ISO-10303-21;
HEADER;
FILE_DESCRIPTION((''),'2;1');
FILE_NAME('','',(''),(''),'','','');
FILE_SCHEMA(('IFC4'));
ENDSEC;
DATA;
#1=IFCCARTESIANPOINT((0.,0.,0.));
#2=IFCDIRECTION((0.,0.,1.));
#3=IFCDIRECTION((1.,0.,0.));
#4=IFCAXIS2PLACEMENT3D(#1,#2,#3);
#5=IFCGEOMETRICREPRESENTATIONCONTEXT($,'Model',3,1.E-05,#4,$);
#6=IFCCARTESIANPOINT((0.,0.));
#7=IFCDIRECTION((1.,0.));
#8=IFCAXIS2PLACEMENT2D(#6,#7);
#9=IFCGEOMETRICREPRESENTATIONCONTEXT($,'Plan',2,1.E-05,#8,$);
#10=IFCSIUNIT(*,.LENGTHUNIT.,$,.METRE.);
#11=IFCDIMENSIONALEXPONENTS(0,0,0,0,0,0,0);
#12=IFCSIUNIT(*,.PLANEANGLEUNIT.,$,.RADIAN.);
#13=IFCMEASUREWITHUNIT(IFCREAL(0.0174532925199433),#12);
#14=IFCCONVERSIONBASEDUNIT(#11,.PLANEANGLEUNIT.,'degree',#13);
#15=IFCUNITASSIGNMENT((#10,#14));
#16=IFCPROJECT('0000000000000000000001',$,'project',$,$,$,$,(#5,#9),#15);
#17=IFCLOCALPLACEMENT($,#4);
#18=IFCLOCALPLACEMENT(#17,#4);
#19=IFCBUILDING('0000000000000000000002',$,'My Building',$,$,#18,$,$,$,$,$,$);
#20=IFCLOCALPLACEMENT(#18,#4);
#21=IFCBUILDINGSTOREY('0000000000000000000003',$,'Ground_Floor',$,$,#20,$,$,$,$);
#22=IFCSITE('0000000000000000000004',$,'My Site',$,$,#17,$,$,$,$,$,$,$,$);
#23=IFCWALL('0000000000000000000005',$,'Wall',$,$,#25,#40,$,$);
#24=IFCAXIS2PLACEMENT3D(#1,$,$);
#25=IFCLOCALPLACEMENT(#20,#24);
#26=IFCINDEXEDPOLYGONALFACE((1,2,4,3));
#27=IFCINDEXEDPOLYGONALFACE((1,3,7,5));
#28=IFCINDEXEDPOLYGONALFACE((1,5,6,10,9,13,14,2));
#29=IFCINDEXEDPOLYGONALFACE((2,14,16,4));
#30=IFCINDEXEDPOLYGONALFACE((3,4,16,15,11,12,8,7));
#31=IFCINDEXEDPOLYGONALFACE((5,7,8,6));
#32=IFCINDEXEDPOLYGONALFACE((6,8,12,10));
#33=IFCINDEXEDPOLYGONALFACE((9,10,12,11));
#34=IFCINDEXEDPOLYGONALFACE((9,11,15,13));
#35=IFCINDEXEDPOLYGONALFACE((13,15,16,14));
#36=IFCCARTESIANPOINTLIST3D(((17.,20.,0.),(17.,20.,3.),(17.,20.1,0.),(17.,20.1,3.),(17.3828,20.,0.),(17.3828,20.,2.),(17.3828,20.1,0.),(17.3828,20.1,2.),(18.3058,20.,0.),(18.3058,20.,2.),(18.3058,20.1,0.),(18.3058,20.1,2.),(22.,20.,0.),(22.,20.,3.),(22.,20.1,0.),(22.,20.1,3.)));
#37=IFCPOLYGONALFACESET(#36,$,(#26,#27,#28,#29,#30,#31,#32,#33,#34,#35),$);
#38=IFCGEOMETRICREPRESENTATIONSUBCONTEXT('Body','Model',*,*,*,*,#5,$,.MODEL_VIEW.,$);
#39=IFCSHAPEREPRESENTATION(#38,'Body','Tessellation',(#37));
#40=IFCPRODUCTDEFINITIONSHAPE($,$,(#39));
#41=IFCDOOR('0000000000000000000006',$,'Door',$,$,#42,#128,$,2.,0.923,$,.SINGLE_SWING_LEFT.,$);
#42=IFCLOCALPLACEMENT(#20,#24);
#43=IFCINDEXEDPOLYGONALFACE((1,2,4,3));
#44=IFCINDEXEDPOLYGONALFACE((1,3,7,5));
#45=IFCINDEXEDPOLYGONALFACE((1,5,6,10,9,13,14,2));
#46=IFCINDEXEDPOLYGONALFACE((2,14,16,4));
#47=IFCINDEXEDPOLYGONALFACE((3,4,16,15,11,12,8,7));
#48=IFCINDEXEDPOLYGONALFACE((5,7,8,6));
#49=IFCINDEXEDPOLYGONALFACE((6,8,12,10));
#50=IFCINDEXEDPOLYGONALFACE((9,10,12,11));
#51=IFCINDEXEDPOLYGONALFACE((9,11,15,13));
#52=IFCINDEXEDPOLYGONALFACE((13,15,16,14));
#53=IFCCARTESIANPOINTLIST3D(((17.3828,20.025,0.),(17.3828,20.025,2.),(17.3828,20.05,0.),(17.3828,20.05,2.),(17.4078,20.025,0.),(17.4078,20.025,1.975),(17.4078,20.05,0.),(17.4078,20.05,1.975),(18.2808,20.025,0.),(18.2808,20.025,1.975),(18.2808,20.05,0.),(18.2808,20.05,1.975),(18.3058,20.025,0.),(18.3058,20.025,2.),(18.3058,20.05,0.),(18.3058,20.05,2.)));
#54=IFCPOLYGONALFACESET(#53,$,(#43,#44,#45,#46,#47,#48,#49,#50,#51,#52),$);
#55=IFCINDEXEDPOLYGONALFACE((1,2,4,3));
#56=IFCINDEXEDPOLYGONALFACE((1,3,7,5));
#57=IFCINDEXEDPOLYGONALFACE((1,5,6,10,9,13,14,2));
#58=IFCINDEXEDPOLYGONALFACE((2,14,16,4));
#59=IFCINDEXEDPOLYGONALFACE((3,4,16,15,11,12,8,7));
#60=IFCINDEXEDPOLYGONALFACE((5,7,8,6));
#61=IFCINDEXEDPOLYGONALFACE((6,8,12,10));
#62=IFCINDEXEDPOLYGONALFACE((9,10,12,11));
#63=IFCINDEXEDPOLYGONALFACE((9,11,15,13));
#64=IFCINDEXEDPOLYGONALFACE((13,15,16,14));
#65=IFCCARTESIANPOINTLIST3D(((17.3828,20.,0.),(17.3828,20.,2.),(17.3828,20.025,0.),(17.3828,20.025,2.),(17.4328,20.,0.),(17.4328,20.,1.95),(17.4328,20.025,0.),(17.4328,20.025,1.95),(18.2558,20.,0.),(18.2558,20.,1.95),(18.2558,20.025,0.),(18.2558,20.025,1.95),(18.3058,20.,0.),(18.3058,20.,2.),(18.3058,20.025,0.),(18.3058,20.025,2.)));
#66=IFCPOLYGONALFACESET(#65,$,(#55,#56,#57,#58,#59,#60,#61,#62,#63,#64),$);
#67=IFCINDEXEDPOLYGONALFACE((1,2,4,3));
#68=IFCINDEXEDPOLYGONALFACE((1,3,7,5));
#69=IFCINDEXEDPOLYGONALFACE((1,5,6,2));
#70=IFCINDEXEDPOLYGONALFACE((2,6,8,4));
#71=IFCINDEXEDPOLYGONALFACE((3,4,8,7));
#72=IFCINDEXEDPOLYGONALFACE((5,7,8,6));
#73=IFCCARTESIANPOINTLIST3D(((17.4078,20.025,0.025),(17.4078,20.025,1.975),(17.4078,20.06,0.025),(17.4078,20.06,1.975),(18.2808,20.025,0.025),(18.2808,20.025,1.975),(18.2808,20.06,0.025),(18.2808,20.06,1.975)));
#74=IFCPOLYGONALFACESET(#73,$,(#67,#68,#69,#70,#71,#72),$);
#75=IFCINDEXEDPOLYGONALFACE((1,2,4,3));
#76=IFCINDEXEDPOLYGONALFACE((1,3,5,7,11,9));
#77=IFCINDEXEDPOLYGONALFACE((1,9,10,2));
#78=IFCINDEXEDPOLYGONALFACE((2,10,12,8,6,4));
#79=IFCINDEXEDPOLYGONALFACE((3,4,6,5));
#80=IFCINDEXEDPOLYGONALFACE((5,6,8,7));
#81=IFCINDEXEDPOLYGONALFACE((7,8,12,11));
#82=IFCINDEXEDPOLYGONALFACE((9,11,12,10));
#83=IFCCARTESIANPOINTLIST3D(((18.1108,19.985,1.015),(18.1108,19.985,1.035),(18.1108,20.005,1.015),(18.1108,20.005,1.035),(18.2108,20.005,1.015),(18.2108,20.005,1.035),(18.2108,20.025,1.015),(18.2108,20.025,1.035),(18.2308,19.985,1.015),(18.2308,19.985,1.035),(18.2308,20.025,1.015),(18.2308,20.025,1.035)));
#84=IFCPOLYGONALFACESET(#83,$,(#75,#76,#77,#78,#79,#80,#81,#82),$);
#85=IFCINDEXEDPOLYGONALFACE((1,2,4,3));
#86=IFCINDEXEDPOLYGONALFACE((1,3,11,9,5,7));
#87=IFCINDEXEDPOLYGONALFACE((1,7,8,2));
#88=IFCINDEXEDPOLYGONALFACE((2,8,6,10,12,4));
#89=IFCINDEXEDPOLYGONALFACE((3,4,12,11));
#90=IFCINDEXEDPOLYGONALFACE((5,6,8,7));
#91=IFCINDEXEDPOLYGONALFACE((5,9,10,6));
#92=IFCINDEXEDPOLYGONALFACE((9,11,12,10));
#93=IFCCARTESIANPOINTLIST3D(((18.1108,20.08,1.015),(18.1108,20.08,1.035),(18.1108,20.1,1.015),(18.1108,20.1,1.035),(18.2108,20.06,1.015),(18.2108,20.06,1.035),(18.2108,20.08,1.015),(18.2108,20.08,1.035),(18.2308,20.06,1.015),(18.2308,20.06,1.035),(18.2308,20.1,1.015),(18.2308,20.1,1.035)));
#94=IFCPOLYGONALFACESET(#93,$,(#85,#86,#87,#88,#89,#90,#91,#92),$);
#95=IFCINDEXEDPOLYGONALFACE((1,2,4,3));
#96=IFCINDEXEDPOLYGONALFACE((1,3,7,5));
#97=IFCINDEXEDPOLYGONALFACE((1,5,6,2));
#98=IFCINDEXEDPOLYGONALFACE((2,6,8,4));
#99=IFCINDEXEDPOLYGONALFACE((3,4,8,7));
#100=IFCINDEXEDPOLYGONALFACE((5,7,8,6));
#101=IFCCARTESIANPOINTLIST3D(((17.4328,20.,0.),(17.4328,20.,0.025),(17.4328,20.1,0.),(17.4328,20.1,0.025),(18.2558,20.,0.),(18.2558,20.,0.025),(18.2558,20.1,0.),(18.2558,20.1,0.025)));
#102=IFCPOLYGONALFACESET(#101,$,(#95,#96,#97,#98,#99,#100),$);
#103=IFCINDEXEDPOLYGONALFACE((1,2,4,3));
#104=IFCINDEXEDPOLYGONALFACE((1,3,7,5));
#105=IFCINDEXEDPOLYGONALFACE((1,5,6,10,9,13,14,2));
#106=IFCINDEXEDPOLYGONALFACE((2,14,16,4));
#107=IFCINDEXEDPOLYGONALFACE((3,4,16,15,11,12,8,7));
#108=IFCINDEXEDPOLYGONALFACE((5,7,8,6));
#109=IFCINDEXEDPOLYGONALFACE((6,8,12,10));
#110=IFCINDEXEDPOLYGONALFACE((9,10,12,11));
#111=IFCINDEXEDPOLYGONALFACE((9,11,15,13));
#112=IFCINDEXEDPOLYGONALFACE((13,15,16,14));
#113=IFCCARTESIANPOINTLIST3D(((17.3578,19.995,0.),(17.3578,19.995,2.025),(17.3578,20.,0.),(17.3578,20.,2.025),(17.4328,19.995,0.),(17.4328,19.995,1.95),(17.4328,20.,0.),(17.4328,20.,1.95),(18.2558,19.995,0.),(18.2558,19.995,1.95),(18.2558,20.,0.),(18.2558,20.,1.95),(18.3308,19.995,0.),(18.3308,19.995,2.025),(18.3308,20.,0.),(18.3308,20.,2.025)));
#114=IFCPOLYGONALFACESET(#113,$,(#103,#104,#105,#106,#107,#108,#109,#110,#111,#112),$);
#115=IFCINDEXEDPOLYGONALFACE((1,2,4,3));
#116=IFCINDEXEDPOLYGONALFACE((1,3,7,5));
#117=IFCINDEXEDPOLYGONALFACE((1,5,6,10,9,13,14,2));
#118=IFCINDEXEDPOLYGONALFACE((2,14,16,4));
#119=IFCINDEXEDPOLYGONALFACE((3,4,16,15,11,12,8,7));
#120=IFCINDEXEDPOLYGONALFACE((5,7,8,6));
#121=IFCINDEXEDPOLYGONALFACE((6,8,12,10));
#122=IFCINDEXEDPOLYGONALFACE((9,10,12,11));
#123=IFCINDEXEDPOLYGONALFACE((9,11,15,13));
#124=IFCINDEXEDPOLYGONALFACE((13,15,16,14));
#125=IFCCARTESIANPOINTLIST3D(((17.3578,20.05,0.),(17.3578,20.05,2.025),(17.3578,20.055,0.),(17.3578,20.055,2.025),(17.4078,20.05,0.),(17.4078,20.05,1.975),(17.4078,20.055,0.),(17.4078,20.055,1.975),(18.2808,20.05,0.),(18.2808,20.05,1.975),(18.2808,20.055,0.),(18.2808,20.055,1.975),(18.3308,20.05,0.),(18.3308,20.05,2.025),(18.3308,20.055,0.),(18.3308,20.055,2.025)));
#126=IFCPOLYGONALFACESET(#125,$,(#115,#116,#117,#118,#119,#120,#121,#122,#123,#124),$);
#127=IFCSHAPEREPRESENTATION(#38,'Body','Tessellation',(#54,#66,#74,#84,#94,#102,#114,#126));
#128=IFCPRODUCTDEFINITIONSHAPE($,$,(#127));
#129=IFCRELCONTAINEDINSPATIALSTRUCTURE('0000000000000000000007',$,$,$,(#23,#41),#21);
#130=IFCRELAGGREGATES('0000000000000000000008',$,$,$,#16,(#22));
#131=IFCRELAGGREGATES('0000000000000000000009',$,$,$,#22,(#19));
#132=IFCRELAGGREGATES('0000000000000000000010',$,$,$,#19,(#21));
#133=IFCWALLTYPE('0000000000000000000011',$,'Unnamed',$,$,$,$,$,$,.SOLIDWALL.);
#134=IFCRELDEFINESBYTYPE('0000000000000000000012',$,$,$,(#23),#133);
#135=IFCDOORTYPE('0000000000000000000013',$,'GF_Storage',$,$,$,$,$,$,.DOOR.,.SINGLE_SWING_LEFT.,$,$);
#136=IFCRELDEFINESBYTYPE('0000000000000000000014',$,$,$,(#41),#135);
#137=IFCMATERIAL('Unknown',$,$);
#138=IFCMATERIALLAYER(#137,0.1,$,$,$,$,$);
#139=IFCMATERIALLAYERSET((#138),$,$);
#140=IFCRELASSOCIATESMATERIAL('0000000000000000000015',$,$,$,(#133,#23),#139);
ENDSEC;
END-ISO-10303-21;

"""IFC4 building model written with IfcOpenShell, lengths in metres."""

from ifc_helpers import new_model, entity, si_unit, converted_unit, frame, origin_with_axes, origin_2d_with_axis, place, context, subcontext, project, spatial, line, indexed_curve, outline, extrude, shape, source, transform, mapped, material, layer, layer_set, layer_usage, type_object, type_shapes, element, fill, save


model = new_model("IFC4")

# Units and contexts
model_context = context("Model", 3, precision=1e-05, world=origin_with_axes())
plan_context = context("Plan", 2, precision=1e-05, world=origin_2d_with_axis())
body_context_1 = subcontext(model_context, "Body", "Model", "MODEL_VIEW")
body_context_2 = subcontext(plan_context, "Body", "Plan", "PLAN_VIEW")
ifc_project = project(units=[si_unit("LENGTHUNIT", "METRE"), converted_unit("PLANEANGLEUNIT", "degree", entity("IfcReal", 0.0174532925199433), si_unit("PLANEANGLEUNIT", "RADIAN"), dimensions=[0, 0, 0, 0, 0, 0, 0])], contexts=[model_context, plan_context])

# Site, building, storey
site_placement = place(None, origin_with_axes())
site = spatial("IfcSite", under=ifc_project, at=site_placement, Name="My Site")
building_placement = place(site_placement, origin_with_axes())
building = spatial("IfcBuilding", under=site, at=building_placement, Name="My Building")
storey_placement = place(building_placement, origin_with_axes())
storey = spatial("IfcBuildingStorey", under=building, at=storey_placement, Name="Ground_Floor")

# Shared definitions
ifc_material = material(Name="Unknown")
ifc_layer = layer(ifc_material, 0.1)
ifc_layer_set = layer_set([ifc_layer])
wall_type = type_object("IfcWallType", Name="Unnamed", PredefinedType="SOLIDWALL", material=ifc_layer_set)

# Wall, opening, door
ifc_layer_usage_1 = layer_usage(ifc_layer_set, "AXIS2", "POSITIVE", 0.0)
wall_1_placement = place(storey_placement, frame((17.0, 20.0, 0.0), z_axis=(0.0, 0.0, 1.0), x_axis=(1.0, 0.0, 0.0)))
wall_1 = element("IfcWall", 1, at=wall_1_placement, inside=storey, type_object=wall_type, material=ifc_layer_usage_1, Name="Wall", context=body_context_1, shape_type="SweptSolid", body=[
    extrude(outline(indexed_curve([(0.0, 0.0), (0.0, 0.1), (5.0, 0.1), (5.0, 0.0)], segments=[line(1, 2, 3, 4, 1)])), origin_with_axes(), (0.0, 0.0, 1.0), 3.0),
])
shared_shape_1 = source(origin_with_axes(), body_context_1, "Body", "SweptSolid", [
    extrude(outline(indexed_curve([(0.0, 0.0), (0.923, 0.0), (0.923, 2.0), (0.0, 2.0)], segments=[line(1, 2, 3, 4, 1)])), frame((0.0, -0.6, 0.0), z_axis=(0.0, -1.0, 0.0), x_axis=(1.0, 0.0, 0.0)), (0.0, 0.0, -1.0), 1.2),
])
opening_1_placement = place(wall_1_placement, frame((0.3828, 0.0, 0.0), z_axis=(0.0, 0.0, 1.0), x_axis=(1.0, 0.0, 0.0)))
opening_1 = element("IfcOpeningElement", 2, at=opening_1_placement, cuts=wall_1, PredefinedType="OPENING", context=body_context_1, shape_type="MappedRepresentation", body=[
    mapped(shared_shape_1, transform((0.0, 0.0, 0.0), x_axis=(1.0, 0.0, 0.0), y_axis=(0.0, 1.0, 0.0), z_axis=(0.0, 0.0, 1.0), scale=1.0)),
])
door_type_1 = type_object("IfcDoorType", Name="GF_Storage", OperationType="SINGLE_SWING_LEFT", PredefinedType="DOOR")
shared_shape_2 = source(origin_with_axes(), body_context_1, "Body", "SweptSolid", [
    extrude(outline(indexed_curve([(0.0, 0.0), (0.0, 2.0), (0.923, 2.0), (0.923, 0.0), (0.898, 0.0), (0.898, 1.975), (0.025, 1.975), (0.025, 0.0)], segments=[line(1, 2, 3, 4, 5, 6, 7, 8, 1)])), frame((0.0, 0.025, 0.0), z_axis=(0.0, -1.0, 0.0), x_axis=(1.0, 0.0, 0.0)), (0.0, 0.0, -1.0), 0.025),
    extrude(outline(indexed_curve([(0.0, 0.0), (0.0, 2.0), (0.923, 2.0), (0.923, 0.0), (0.873, 0.0), (0.873, 1.95), (0.05, 1.95), (0.05, 0.0)], segments=[line(1, 2, 3, 4, 5, 6, 7, 8, 1)])), frame((0.0, 0.0, 0.0), z_axis=(0.0, -1.0, 0.0), x_axis=(1.0, 0.0, 0.0)), (0.0, 0.0, -1.0), 0.025),
    extrude(outline(indexed_curve([(0.0, 0.0), (0.873, 0.0), (0.873, 0.035), (0.0, 0.035)], segments=[line(1, 2, 3, 4, 1)])), frame((0.025, 0.025, 0.025), z_axis=(0.0, 0.0, 1.0), x_axis=(1.0, 0.0, 0.0)), (0.0, 0.0, 1.0), 1.95),
    extrude(outline(indexed_curve([(0.0, 0.0), (0.0, -0.04), (-0.12, -0.04), (-0.12, -0.02), (-0.02, -0.02), (-0.02, 0.0)], segments=[line(1, 2, 3, 4, 5, 6, 1)])), frame((0.848, 0.025, 1.015), z_axis=(0.0, 0.0, 1.0), x_axis=(1.0, 0.0, 0.0)), (0.0, 0.0, 1.0), 0.02),
    extrude(outline(indexed_curve([(0.0, 0.0), (0.0, 0.04), (-0.12, 0.04), (-0.12, 0.02), (-0.02, 0.02), (-0.02, 0.0)], segments=[line(1, 2, 3, 4, 5, 6, 1)])), frame((0.848, 0.06, 1.015), z_axis=(0.0, 0.0, 1.0), x_axis=(1.0, 0.0, 0.0)), (0.0, 0.0, 1.0), 0.02),
    extrude(outline(indexed_curve([(0.0, 0.0), (0.823, 0.0), (0.823, 0.1), (0.0, 0.1)], segments=[line(1, 2, 3, 4, 1)])), frame((0.05, 0.0, 0.0), z_axis=(0.0, 0.0, 1.0), x_axis=(1.0, 0.0, 0.0)), (0.0, 0.0, 1.0), 0.025),
    extrude(outline(indexed_curve([(0.0, 0.0), (0.0, 2.025), (0.973, 2.025), (0.973, 0.0), (0.898, 0.0), (0.898, 1.95), (0.075, 1.95), (0.075, 0.0)], segments=[line(1, 2, 3, 4, 5, 6, 7, 8, 1)])), frame((-0.025, -0.005, 0.0), z_axis=(0.0, -1.0, 0.0), x_axis=(1.0, 0.0, 0.0)), (0.0, 0.0, -1.0), 0.005),
    extrude(outline(indexed_curve([(0.0, 0.0), (0.0, 2.025), (0.973, 2.025), (0.973, 0.0), (0.923, 0.0), (0.923, 1.975), (0.05, 1.975), (0.05, 0.0)], segments=[line(1, 2, 3, 4, 5, 6, 7, 8, 1)])), frame((-0.025, 0.05, 0.0), z_axis=(0.0, -1.0, 0.0), x_axis=(1.0, 0.0, 0.0)), (0.0, 0.0, -1.0), 0.005),
])
shared_shape_3 = source(origin_with_axes(), body_context_2, "Body", "Curve2D", [
    entity("IfcIndexedPolyCurve", entity("IfcCartesianPointList2D", [[0.0, 0.0], [0.0, 0.05], [0.025, 0.05], [0.025, 0.025], [0.05, 0.025], [0.05, 0.0]]), [entity("IfcLineIndex", [1, 2, 3, 4, 5, 6, 1])]),
    entity("IfcIndexedPolyCurve", entity("IfcCartesianPointList2D", [[0.923, 0.0], [0.923, 0.05], [0.898, 0.05], [0.898, 0.025], [0.873, 0.025], [0.873, 0.0]]), [entity("IfcLineIndex", [1, 2, 3, 4, 5, 6, 1])]),
    entity("IfcTrimmedCurve", entity("IfcEllipse", entity("IfcAxis2Placement2D", entity("IfcCartesianPoint", [0.06, 0.05]), entity("IfcDirection", [1.0, 0.0])), 0.838, 0.873), [entity("IfcCartesianPoint", [0.898, 0.05])], [entity("IfcCartesianPoint", [0.06, 0.923])], True, "CARTESIAN"),
    entity("IfcIndexedPolyCurve", entity("IfcCartesianPointList2D", [[0.025, 0.05], [0.06, 0.05], [0.06, 0.923], [0.025, 0.923]]), [entity("IfcLineIndex", [1, 2, 3, 4, 1])]),
])
type_shapes(door_type_1, [shared_shape_2, shared_shape_3])
door_1_placement = place(opening_1_placement, frame((0.0, 0.0, 0.0), z_axis=(0.0, 0.0, 1.0), x_axis=(1.0, 0.0, 0.0)))
door_1 = element("IfcDoor", 3, at=door_1_placement, inside=storey, type_object=door_type_1, Name="Door", OperationType="SINGLE_SWING_LEFT", OverallHeight=2.0, OverallWidth=0.923, shapes=[
    shape(body_context_1, "Body", "MappedRepresentation", [mapped(shared_shape_2, transform((0.0, 0.0, 0.0), x_axis=(1.0, 0.0, 0.0), y_axis=(0.0, 1.0, 0.0), z_axis=(0.0, 0.0, 1.0), scale=1.0))]),
    shape(body_context_2, "Body", "MappedRepresentation", [mapped(shared_shape_3, transform((0.0, 0.0, 0.0), x_axis=(1.0, 0.0, 0.0), y_axis=(0.0, 1.0, 0.0), z_axis=(0.0, 0.0, 1.0), scale=1.0))]),
])
fill(opening_1, door_1)

save(model, "model.ifc")
